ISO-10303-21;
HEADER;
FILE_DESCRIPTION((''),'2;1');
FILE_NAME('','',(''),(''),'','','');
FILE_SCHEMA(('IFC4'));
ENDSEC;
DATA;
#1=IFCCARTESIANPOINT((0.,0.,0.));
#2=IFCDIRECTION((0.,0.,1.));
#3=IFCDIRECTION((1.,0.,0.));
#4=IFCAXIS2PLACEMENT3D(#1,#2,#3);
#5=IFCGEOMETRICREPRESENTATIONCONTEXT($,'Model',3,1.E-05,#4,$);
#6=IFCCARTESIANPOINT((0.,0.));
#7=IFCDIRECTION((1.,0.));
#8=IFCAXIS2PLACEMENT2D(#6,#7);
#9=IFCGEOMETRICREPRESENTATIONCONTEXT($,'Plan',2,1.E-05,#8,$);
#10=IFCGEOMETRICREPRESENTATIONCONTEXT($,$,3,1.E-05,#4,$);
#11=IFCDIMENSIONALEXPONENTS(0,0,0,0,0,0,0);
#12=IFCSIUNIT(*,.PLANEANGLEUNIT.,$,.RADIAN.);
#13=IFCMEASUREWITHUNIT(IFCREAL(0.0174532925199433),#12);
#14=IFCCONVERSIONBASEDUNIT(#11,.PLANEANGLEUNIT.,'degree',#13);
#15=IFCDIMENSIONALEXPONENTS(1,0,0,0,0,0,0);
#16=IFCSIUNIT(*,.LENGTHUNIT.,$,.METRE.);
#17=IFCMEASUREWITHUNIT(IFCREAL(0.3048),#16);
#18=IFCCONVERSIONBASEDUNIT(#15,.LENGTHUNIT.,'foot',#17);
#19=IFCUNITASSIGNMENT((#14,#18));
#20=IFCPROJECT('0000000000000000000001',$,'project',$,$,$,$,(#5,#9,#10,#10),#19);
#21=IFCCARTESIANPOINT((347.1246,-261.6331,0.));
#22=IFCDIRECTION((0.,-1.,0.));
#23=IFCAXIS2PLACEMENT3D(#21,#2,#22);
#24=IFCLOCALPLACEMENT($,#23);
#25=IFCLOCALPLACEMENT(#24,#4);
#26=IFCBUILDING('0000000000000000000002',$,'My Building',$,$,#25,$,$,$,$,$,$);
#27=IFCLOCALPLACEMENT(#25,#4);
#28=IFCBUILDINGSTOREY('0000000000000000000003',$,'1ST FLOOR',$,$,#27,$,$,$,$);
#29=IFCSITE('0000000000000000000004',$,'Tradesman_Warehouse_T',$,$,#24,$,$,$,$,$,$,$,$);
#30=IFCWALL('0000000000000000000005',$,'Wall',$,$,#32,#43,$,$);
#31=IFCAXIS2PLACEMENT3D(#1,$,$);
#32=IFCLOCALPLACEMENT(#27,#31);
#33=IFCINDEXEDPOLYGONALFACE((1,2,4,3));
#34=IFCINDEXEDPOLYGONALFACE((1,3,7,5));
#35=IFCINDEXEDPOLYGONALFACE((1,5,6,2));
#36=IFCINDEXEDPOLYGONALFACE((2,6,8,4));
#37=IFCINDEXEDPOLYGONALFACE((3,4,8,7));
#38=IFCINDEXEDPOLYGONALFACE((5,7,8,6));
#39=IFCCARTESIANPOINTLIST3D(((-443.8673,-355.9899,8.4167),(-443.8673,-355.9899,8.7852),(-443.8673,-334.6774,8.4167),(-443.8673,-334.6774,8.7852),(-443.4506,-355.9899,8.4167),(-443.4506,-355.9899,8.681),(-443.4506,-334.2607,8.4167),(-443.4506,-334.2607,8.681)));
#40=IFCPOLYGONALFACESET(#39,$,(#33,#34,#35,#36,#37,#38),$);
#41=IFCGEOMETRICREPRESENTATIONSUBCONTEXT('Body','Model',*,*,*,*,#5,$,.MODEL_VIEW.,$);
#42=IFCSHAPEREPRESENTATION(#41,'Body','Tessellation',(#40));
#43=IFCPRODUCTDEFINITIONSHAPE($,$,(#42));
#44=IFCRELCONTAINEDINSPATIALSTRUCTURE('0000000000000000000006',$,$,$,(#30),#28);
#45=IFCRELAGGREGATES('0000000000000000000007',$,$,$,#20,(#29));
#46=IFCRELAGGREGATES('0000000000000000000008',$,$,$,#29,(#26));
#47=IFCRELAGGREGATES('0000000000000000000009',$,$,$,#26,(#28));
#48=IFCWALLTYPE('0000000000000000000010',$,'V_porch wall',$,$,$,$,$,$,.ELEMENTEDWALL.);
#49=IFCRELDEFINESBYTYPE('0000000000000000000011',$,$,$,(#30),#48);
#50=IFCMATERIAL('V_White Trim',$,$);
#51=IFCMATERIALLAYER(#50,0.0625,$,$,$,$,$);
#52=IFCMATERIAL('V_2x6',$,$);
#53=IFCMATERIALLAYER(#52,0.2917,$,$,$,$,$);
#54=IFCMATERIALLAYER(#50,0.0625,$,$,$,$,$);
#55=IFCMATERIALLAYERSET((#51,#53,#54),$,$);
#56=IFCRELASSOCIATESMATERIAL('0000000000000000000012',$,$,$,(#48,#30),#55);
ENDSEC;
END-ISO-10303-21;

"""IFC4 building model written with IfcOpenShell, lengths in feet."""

from ifc_helpers import new_model, entity, si_unit, converted_unit, frame, origin_with_axes, origin_2d_with_axis, place, context, subcontext, project, spatial, indexed_curve, outline, extrude, clip, halfspace, material, layer, layer_set, layer_usage, type_object, element, save


model = new_model("IFC4")

# Units and contexts
model_context = context("Model", 3, precision=1e-05, world=origin_with_axes())
plan_context = context("Plan", 2, precision=1e-05, world=origin_2d_with_axis())
context_of_model = context(None, 3, precision=1e-05, world=origin_with_axes())
body_context = subcontext(model_context, "Body", "Model", "MODEL_VIEW")
ifc_project = project(units=[converted_unit("PLANEANGLEUNIT", "degree", entity("IfcReal", 0.0174532925199433), si_unit("PLANEANGLEUNIT", "RADIAN"), dimensions=[0, 0, 0, 0, 0, 0, 0]), converted_unit("LENGTHUNIT", "foot", entity("IfcReal", 0.3048), si_unit("LENGTHUNIT", "METRE"), dimensions=[1, 0, 0, 0, 0, 0, 0])], contexts=[model_context, plan_context, context_of_model, context_of_model])

# Site, building, storey
site_placement = place(None, frame((347.1246, -261.6331, 0.0), z_axis=(0.0, 0.0, 1.0), x_axis=(0.0, -1.0, 0.0)))
site = spatial("IfcSite", under=ifc_project, at=site_placement, Name="Tradesman_Warehouse_T")
building_placement = place(site_placement, frame((0.0, 0.0, 0.0), z_axis=(0.0, 0.0, 1.0), x_axis=(1.0, 0.0, 0.0)))
building = spatial("IfcBuilding", under=site, at=building_placement, Name="My Building")
storey_placement = place(building_placement, frame((0.0, 0.0, 0.0), z_axis=(0.0, 0.0, 1.0), x_axis=(1.0, 0.0, 0.0)))
storey = spatial("IfcBuildingStorey", under=building, at=storey_placement, Name="1ST FLOOR")

# Shared definitions
ifc_material_1 = material(Name="V_White Trim")

# Shared definitions
ifc_layer_1 = layer(ifc_material_1, 0.0625)
ifc_material_2 = material(Name="V_2x6")
ifc_layer_2 = layer(ifc_material_2, 0.2917)
ifc_layer_3 = layer(ifc_material_1, 0.0625)
ifc_layer_set_1 = layer_set([ifc_layer_1, ifc_layer_2, ifc_layer_3])
wall_type_1 = type_object("IfcWallType", Name="V_porch wall", PredefinedType="ELEMENTEDWALL", material=ifc_layer_set_1)

# Wall
ifc_layer_usage_1 = layer_usage(ifc_layer_set_1, "AXIS2", "POSITIVE", 0.0)
wall_1_placement = place(storey_placement, frame((-443.4506, -355.9899, 8.4167), z_axis=(0.0, 0.0, 1.0), x_axis=(0.0, 1.0, 0.0)))
element("IfcWall", 1, at=wall_1_placement, inside=storey, type_object=wall_type_1, material=ifc_layer_usage_1, Name="Wall", context=body_context, shape_type="Clipping", body=[
    clip(clip(extrude(outline(indexed_curve([(0.0, 0.0), (0.0, 0.4167), (21.7292, 0.4167), (21.7292, 0.0), (0.0, 0.0)], self_intersect=False)), origin_with_axes(), (0.0, 0.0, 1.0), 8.7852), halfspace(frame((0.0, 0.4167, 0.3685), z_axis=(0.0, -0.242599, 0.970127), x_axis=(-1.0, 0.0, 0.0)), False)), halfspace(frame((21.7292, 0.0, -8.4167), z_axis=(0.707104, 0.707109, 0.0), x_axis=(0.707109, -0.707104, 0.0)), False)),
])

save(model, "model.ifc")
